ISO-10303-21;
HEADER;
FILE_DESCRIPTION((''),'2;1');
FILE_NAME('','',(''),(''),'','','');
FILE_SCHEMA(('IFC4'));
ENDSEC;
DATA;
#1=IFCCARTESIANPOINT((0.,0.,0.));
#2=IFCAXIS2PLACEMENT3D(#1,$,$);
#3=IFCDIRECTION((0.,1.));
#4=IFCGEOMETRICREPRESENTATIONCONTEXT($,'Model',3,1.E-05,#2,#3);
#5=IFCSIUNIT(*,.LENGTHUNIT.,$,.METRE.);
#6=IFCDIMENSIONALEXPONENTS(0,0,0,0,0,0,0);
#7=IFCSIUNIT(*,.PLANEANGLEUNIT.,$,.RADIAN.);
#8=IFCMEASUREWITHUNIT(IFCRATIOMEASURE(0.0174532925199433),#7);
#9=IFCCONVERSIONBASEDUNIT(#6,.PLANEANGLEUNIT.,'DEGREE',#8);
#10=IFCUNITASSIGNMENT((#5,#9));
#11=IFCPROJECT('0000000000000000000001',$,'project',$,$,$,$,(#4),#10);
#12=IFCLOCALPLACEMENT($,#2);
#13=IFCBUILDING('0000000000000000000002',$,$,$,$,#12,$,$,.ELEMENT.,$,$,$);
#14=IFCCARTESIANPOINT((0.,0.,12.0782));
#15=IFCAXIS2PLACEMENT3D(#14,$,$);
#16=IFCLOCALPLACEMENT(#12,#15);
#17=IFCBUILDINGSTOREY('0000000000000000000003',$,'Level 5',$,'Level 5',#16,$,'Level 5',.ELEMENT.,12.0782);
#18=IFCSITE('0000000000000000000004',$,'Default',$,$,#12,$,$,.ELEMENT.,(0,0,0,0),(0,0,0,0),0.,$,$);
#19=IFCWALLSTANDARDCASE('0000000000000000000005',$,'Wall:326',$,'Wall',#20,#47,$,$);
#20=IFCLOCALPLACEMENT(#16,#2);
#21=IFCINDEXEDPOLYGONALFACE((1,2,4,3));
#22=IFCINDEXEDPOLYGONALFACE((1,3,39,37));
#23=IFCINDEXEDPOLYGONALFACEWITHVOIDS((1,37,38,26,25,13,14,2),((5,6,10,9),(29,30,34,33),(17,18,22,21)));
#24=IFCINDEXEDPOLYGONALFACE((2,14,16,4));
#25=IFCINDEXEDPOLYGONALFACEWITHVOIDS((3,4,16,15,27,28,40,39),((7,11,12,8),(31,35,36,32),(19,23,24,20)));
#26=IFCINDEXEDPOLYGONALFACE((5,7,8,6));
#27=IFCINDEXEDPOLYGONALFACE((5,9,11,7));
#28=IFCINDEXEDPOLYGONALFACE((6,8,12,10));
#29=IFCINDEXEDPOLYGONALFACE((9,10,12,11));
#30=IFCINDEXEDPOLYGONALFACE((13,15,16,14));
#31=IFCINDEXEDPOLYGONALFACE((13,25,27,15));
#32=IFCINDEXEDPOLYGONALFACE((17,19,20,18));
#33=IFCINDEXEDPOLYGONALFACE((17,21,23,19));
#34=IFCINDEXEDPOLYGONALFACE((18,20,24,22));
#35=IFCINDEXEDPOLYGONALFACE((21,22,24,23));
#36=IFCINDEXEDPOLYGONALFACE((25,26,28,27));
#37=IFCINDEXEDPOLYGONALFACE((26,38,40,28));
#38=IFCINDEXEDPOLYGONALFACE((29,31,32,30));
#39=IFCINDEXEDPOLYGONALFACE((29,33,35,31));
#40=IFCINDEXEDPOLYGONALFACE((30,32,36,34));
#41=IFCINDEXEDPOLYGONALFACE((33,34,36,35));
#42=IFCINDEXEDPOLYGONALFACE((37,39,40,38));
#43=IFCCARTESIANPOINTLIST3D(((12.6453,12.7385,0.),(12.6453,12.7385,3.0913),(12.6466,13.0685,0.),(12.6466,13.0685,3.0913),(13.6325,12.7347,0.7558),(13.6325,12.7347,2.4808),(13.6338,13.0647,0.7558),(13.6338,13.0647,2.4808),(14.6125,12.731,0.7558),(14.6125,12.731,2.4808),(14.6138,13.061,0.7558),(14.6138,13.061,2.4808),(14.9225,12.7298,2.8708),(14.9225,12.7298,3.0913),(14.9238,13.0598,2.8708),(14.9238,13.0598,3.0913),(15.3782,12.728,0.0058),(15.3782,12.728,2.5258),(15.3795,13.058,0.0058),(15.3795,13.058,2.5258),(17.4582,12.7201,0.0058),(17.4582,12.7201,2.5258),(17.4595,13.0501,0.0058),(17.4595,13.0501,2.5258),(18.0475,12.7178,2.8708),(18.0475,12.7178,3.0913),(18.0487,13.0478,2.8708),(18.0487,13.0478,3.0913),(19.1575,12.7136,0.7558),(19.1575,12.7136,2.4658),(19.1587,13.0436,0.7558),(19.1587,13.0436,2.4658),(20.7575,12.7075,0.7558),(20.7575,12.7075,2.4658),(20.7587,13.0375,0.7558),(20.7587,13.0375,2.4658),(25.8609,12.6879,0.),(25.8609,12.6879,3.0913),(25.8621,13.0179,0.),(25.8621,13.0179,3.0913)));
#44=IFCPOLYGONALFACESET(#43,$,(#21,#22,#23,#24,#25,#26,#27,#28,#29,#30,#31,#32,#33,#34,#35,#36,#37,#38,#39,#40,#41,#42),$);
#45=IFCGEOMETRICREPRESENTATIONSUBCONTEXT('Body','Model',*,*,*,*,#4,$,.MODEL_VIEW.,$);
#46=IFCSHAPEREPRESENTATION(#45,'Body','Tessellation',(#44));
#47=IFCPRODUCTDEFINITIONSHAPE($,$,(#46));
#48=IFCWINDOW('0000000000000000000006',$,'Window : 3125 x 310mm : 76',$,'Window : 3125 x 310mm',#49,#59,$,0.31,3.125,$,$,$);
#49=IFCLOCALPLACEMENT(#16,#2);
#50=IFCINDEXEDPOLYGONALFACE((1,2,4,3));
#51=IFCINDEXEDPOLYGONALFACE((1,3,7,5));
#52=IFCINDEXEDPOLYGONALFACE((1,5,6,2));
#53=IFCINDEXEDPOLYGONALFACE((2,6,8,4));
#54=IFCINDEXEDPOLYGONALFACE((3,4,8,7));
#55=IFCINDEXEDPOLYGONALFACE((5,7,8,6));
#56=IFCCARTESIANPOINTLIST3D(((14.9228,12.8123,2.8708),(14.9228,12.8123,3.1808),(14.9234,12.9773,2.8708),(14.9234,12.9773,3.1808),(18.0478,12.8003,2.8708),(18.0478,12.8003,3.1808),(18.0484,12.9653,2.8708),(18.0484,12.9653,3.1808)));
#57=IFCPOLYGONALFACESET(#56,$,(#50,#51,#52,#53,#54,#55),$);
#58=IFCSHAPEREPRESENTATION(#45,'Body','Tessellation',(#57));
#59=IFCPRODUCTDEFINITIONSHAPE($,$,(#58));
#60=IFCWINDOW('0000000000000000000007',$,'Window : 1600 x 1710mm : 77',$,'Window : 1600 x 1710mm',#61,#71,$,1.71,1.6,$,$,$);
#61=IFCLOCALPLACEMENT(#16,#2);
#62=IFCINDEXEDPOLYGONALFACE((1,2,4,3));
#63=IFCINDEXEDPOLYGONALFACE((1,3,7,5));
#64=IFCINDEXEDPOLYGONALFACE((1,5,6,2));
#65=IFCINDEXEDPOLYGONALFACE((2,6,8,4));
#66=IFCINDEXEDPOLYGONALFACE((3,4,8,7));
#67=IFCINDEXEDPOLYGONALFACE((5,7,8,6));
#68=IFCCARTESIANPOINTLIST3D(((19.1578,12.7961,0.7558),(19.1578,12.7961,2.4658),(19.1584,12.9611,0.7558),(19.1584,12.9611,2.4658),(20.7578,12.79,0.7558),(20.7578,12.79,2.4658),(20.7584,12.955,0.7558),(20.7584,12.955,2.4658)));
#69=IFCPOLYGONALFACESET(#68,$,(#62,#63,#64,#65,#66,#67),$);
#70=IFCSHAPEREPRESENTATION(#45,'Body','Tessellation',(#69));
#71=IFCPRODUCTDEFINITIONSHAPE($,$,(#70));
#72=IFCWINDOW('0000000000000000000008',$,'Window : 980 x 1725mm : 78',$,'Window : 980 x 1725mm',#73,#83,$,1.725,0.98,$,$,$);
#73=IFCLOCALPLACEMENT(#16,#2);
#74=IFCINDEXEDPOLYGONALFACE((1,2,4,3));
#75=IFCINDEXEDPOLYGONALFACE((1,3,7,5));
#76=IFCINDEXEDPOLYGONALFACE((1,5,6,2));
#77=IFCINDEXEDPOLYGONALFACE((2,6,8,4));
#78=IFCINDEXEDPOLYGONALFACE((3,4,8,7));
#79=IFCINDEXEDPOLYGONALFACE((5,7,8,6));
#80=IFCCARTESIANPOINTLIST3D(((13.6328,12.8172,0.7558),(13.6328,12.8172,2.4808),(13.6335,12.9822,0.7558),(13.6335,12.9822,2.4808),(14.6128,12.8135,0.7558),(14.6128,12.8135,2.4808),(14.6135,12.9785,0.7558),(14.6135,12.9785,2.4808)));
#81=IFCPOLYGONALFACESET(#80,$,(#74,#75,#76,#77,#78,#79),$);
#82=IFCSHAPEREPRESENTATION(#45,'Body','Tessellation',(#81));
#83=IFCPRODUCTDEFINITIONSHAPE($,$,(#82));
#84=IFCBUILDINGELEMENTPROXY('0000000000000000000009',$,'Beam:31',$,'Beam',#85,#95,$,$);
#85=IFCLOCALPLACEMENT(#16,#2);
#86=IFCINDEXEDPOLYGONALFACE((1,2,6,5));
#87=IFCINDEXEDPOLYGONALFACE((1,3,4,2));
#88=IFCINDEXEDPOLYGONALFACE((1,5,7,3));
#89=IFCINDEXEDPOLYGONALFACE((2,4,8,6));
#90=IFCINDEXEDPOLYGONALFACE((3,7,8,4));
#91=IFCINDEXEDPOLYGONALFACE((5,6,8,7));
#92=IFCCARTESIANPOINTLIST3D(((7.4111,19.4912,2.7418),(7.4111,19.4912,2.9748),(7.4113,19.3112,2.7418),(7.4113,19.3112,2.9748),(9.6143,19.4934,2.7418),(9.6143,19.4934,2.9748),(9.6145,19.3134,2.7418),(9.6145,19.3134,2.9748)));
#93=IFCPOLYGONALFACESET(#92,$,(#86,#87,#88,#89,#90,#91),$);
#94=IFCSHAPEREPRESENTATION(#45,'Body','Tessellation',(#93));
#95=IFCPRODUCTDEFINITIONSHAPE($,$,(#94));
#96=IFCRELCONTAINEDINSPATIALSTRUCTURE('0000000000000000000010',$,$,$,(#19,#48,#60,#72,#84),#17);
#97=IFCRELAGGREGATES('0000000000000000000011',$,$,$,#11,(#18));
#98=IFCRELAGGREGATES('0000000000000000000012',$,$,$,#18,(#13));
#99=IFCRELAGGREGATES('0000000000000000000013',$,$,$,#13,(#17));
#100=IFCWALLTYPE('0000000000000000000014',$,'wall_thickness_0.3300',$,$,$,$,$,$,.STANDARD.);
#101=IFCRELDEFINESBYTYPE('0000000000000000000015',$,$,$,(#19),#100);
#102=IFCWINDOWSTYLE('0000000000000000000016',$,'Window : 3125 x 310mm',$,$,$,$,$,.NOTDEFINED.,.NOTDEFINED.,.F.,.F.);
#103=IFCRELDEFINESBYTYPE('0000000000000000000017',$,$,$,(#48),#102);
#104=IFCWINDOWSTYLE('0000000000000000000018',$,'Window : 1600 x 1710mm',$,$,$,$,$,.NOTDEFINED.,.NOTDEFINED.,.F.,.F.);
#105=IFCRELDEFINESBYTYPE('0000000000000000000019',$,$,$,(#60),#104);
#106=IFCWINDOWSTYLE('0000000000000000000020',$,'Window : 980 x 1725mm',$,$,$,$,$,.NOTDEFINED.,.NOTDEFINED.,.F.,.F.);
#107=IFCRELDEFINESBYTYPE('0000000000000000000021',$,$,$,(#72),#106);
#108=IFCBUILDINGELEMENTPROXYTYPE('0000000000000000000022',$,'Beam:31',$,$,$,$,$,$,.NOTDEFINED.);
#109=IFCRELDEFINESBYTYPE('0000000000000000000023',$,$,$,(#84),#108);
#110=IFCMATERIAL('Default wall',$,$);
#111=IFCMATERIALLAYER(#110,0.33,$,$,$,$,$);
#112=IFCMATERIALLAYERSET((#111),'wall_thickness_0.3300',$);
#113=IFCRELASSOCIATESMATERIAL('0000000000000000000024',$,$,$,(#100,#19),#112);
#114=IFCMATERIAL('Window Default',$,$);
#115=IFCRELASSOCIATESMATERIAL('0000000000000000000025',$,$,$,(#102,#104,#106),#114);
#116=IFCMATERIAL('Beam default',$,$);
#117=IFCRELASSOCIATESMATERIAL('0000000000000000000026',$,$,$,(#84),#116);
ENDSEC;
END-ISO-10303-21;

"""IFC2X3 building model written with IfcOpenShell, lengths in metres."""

from ifc_helpers import new_model, entity, si_unit, converted_unit, direction, frame, frame_2d, origin, origin_2d_with_axis, place, context, subcontext, project, spatial, polyline, rectangle, outline, extrude, clip, halfspace, source, transform, mapped, material, layer, layer_set, layer_usage, type_object, type_shapes, element, fill, save


model = new_model("IFC2X3")

# Units and contexts
model_context = context("Model", 3, precision=1e-05, world=origin(), true_north=direction((0.0, 1.0)))
body_context = subcontext(model_context, "Body", "Model", "MODEL_VIEW")
ifc_project = project(units=[si_unit("LENGTHUNIT", "METRE"), converted_unit("PLANEANGLEUNIT", "DEGREE", entity("IfcRatioMeasure", 0.0174532925199433), si_unit("PLANEANGLEUNIT", "RADIAN"), dimensions=[0, 0, 0, 0, 0, 0, 0])], contexts=[model_context])

# Site, building, storey
placement_1 = place(None, origin())
site = spatial("IfcSite", under=ifc_project, at=placement_1, Name="Default", CompositionType="ELEMENT", RefLatitude=(0, 0, 0, 0), RefLongitude=(0, 0, 0, 0), RefElevation=0.0)
building = spatial("IfcBuilding", under=site, at=placement_1, CompositionType="ELEMENT")
storey_placement = place(placement_1, frame((0.0, 0.0, 12.0782)))
storey = spatial("IfcBuildingStorey", under=building, at=storey_placement, Name="Level 5", ObjectType="Level 5", LongName="Level 5", CompositionType="ELEMENT", Elevation=12.0782)

# Shared definitions
ifc_material_1 = material(Name="Default wall")

# Shared definitions
ifc_material_2 = material(Name="Window Default")

# Wall, openings, windows
ifc_layer_1 = layer(ifc_material_1, 0.33)
ifc_layer_set_1 = layer_set([ifc_layer_1], Name="wall_thickness_0.3300")
ifc_layer_usage_1 = layer_usage(ifc_layer_set_1, "AXIS2", "POSITIVE", -0.165)
wall_type_1 = type_object("IfcWallType", Name="wall_thickness_0.3300", PredefinedType="STANDARD", material=ifc_layer_set_1)
wall_1_placement = place(storey_placement, frame((12.6459, 12.9035, 0.0), z_axis=(0.0, 0.0, 1.0), x_axis=(0.999993, -0.003825, 0.0)))
wall_1 = element("IfcWallStandardCase", 1, at=wall_1_placement, inside=storey, type_object=wall_type_1, material=ifc_layer_usage_1, Name="Wall:326", ObjectType="Wall", context=body_context, shape_type="Clipping", body=[
    clip(extrude(outline(polyline([(13.2156, -0.165), (13.2156, 0.165), (0.0, 0.165), (0.0, -0.165), (13.2156, -0.165)])), origin(), (0.0, 0.0, 1.0), 3.0913), halfspace(frame((-24.7046, 6.5959, 8.9869), z_axis=(-0.002803, -0.38913, 0.921178), x_axis=(0.999982, -0.005993, 0.000511)), False)),
])
opening_1_placement = place(wall_1_placement, frame((2.7329, -0.165, 0.0058)))
element("IfcOpeningElement", 2, at=opening_1_placement, cuts=wall_1, ObjectType="Opening", context=body_context, shape_type="SweptSolid", body=[
    extrude(rectangle(XDim=2.08, YDim=2.52, at=frame_2d((1.26, 1.04), x_axis=(0.0, 1.0))), frame((0.0, 0.0, 0.0), z_axis=(0.0, 1.0, 0.0), x_axis=(0.0, 0.0, 1.0)), (0.0, 0.0, 1.0), 0.33),
])
opening_2_placement = place(wall_1_placement, frame((2.2772, -0.165, 2.8708)))
opening_2 = element("IfcOpeningElement", 3, at=opening_2_placement, cuts=wall_1, ObjectType="Opening", context=body_context, shape_type="SweptSolid", body=[
    extrude(rectangle(XDim=3.125, YDim=0.31, at=frame_2d((0.155, 1.5625), x_axis=(0.0, 1.0))), frame((0.0, 0.0, 0.0), z_axis=(0.0, 1.0, 0.0), x_axis=(0.0, 0.0, 1.0)), (0.0, 0.0, 1.0), 0.33),
])
opening_3_placement = place(wall_1_placement, frame((6.5122, -0.165, 0.7558)))
opening_3 = element("IfcOpeningElement", 4, at=opening_3_placement, cuts=wall_1, ObjectType="Opening", context=body_context, shape_type="SweptSolid", body=[
    extrude(rectangle(XDim=1.6, YDim=1.71, at=frame_2d((0.855, 0.8), x_axis=(0.0, 1.0))), frame((0.0, 0.0, 0.0), z_axis=(0.0, 1.0, 0.0), x_axis=(0.0, 0.0, 1.0)), (0.0, 0.0, 1.0), 0.33),
])
opening_4_placement = place(wall_1_placement, frame((0.9872, -0.165, 0.7558)))
opening_4 = element("IfcOpeningElement", 5, at=opening_4_placement, cuts=wall_1, ObjectType="Opening", context=body_context, shape_type="SweptSolid", body=[
    extrude(rectangle(XDim=0.98, YDim=1.725, at=frame_2d((0.8625, 0.49), x_axis=(0.0, 1.0))), frame((0.0, 0.0, 0.0), z_axis=(0.0, 1.0, 0.0), x_axis=(0.0, 0.0, 1.0)), (0.0, 0.0, 1.0), 0.33),
])
window_style_1 = type_object("IfcWindowStyle", Name="Window : 3125 x 310mm", ConstructionType="NOTDEFINED", OperationType="NOTDEFINED", ParameterTakesPrecedence=False, Sizeable=False, material=ifc_material_2)
shared_shape_1 = source(origin(), body_context, "Body", "SweptSolid", [
    extrude(rectangle(XDim=0.165, YDim=3.125, at=origin_2d_with_axis()), frame((1.5625, 0.165, 0.0), z_axis=(0.0, 0.0, 1.0), x_axis=(0.0, 1.0, 0.0)), (0.0, 0.0, 1.0), 0.31),
])
type_shapes(window_style_1, [shared_shape_1])
window_1_placement = place(opening_2_placement, origin())
window_1 = element("IfcWindow", 6, at=window_1_placement, inside=storey, type_object=window_style_1, Name="Window : 3125 x 310mm : 76", ObjectType="Window : 3125 x 310mm", OverallHeight=0.31, OverallWidth=3.125, context=body_context, shape_type="MappedRepresentation", body=[
    mapped(shared_shape_1, transform((0.0, 0.0, 0.0), scale=1.0)),
])
fill(opening_2, window_1)
window_style_2 = type_object("IfcWindowStyle", Name="Window : 1600 x 1710mm", ConstructionType="NOTDEFINED", OperationType="NOTDEFINED", ParameterTakesPrecedence=False, Sizeable=False, material=ifc_material_2)
shared_shape_2 = source(origin(), body_context, "Body", "SweptSolid", [
    extrude(rectangle(XDim=0.165, YDim=1.6, at=origin_2d_with_axis()), frame((0.8, 0.165, 0.0), z_axis=(0.0, 0.0, 1.0), x_axis=(0.0, 1.0, 0.0)), (0.0, 0.0, 1.0), 1.71),
])
type_shapes(window_style_2, [shared_shape_2])
window_2_placement = place(opening_3_placement, origin())
window_2 = element("IfcWindow", 7, at=window_2_placement, inside=storey, type_object=window_style_2, Name="Window : 1600 x 1710mm : 77", ObjectType="Window : 1600 x 1710mm", OverallHeight=1.71, OverallWidth=1.6, context=body_context, shape_type="MappedRepresentation", body=[
    mapped(shared_shape_2, transform((0.0, 0.0, 0.0), scale=1.0)),
])
fill(opening_3, window_2)
window_style_3 = type_object("IfcWindowStyle", Name="Window : 980 x 1725mm", ConstructionType="NOTDEFINED", OperationType="NOTDEFINED", ParameterTakesPrecedence=False, Sizeable=False, material=ifc_material_2)
shared_shape_3 = source(origin(), body_context, "Body", "SweptSolid", [
    extrude(rectangle(XDim=0.165, YDim=0.98, at=origin_2d_with_axis()), frame((0.49, 0.165, 0.0), z_axis=(0.0, 0.0, 1.0), x_axis=(0.0, 1.0, 0.0)), (0.0, 0.0, 1.0), 1.725),
])
type_shapes(window_style_3, [shared_shape_3])
window_3_placement = place(opening_4_placement, origin())
window_3 = element("IfcWindow", 8, at=window_3_placement, inside=storey, type_object=window_style_3, Name="Window : 980 x 1725mm : 78", ObjectType="Window : 980 x 1725mm", OverallHeight=1.725, OverallWidth=0.98, context=body_context, shape_type="MappedRepresentation", body=[
    mapped(shared_shape_3, transform((0.0, 0.0, 0.0), scale=1.0)),
])
fill(opening_4, window_3)

# Building element proxy
ifc_material_3 = material(Name="Beam default")
building_element_proxy_type = type_object("IfcBuildingElementProxyType", Name="Beam:31", PredefinedType="NOTDEFINED")
shared_shape_4 = source(origin(), body_context, "Body", "SweptSolid", [
    extrude(outline(polyline([(2.2032, -0.09), (2.2032, 0.09), (0.0, 0.09), (0.0, -0.09), (2.2032, -0.09)])), origin(), (0.0, 0.0, 1.0), 0.233),
])
type_shapes(building_element_proxy_type, [shared_shape_4])
placement_2 = place(placement_1, frame((0.0, 0.0, 14.82)))
proxy_placement = place(placement_2, frame((7.4112, 19.4012, 0.0), z_axis=(0.0, 0.0, 1.0), x_axis=(1.0, 0.000988, 0.0)))
element("IfcBuildingElementProxy", 9, at=proxy_placement, inside=storey, type_object=building_element_proxy_type, material=ifc_material_3, Name="Beam:31", ObjectType="Beam", context=body_context, shape_type="MappedRepresentation", body=[
    mapped(shared_shape_4, transform((0.0, 0.0, 0.0), scale=1.0)),
])

save(model, "model.ifc")
